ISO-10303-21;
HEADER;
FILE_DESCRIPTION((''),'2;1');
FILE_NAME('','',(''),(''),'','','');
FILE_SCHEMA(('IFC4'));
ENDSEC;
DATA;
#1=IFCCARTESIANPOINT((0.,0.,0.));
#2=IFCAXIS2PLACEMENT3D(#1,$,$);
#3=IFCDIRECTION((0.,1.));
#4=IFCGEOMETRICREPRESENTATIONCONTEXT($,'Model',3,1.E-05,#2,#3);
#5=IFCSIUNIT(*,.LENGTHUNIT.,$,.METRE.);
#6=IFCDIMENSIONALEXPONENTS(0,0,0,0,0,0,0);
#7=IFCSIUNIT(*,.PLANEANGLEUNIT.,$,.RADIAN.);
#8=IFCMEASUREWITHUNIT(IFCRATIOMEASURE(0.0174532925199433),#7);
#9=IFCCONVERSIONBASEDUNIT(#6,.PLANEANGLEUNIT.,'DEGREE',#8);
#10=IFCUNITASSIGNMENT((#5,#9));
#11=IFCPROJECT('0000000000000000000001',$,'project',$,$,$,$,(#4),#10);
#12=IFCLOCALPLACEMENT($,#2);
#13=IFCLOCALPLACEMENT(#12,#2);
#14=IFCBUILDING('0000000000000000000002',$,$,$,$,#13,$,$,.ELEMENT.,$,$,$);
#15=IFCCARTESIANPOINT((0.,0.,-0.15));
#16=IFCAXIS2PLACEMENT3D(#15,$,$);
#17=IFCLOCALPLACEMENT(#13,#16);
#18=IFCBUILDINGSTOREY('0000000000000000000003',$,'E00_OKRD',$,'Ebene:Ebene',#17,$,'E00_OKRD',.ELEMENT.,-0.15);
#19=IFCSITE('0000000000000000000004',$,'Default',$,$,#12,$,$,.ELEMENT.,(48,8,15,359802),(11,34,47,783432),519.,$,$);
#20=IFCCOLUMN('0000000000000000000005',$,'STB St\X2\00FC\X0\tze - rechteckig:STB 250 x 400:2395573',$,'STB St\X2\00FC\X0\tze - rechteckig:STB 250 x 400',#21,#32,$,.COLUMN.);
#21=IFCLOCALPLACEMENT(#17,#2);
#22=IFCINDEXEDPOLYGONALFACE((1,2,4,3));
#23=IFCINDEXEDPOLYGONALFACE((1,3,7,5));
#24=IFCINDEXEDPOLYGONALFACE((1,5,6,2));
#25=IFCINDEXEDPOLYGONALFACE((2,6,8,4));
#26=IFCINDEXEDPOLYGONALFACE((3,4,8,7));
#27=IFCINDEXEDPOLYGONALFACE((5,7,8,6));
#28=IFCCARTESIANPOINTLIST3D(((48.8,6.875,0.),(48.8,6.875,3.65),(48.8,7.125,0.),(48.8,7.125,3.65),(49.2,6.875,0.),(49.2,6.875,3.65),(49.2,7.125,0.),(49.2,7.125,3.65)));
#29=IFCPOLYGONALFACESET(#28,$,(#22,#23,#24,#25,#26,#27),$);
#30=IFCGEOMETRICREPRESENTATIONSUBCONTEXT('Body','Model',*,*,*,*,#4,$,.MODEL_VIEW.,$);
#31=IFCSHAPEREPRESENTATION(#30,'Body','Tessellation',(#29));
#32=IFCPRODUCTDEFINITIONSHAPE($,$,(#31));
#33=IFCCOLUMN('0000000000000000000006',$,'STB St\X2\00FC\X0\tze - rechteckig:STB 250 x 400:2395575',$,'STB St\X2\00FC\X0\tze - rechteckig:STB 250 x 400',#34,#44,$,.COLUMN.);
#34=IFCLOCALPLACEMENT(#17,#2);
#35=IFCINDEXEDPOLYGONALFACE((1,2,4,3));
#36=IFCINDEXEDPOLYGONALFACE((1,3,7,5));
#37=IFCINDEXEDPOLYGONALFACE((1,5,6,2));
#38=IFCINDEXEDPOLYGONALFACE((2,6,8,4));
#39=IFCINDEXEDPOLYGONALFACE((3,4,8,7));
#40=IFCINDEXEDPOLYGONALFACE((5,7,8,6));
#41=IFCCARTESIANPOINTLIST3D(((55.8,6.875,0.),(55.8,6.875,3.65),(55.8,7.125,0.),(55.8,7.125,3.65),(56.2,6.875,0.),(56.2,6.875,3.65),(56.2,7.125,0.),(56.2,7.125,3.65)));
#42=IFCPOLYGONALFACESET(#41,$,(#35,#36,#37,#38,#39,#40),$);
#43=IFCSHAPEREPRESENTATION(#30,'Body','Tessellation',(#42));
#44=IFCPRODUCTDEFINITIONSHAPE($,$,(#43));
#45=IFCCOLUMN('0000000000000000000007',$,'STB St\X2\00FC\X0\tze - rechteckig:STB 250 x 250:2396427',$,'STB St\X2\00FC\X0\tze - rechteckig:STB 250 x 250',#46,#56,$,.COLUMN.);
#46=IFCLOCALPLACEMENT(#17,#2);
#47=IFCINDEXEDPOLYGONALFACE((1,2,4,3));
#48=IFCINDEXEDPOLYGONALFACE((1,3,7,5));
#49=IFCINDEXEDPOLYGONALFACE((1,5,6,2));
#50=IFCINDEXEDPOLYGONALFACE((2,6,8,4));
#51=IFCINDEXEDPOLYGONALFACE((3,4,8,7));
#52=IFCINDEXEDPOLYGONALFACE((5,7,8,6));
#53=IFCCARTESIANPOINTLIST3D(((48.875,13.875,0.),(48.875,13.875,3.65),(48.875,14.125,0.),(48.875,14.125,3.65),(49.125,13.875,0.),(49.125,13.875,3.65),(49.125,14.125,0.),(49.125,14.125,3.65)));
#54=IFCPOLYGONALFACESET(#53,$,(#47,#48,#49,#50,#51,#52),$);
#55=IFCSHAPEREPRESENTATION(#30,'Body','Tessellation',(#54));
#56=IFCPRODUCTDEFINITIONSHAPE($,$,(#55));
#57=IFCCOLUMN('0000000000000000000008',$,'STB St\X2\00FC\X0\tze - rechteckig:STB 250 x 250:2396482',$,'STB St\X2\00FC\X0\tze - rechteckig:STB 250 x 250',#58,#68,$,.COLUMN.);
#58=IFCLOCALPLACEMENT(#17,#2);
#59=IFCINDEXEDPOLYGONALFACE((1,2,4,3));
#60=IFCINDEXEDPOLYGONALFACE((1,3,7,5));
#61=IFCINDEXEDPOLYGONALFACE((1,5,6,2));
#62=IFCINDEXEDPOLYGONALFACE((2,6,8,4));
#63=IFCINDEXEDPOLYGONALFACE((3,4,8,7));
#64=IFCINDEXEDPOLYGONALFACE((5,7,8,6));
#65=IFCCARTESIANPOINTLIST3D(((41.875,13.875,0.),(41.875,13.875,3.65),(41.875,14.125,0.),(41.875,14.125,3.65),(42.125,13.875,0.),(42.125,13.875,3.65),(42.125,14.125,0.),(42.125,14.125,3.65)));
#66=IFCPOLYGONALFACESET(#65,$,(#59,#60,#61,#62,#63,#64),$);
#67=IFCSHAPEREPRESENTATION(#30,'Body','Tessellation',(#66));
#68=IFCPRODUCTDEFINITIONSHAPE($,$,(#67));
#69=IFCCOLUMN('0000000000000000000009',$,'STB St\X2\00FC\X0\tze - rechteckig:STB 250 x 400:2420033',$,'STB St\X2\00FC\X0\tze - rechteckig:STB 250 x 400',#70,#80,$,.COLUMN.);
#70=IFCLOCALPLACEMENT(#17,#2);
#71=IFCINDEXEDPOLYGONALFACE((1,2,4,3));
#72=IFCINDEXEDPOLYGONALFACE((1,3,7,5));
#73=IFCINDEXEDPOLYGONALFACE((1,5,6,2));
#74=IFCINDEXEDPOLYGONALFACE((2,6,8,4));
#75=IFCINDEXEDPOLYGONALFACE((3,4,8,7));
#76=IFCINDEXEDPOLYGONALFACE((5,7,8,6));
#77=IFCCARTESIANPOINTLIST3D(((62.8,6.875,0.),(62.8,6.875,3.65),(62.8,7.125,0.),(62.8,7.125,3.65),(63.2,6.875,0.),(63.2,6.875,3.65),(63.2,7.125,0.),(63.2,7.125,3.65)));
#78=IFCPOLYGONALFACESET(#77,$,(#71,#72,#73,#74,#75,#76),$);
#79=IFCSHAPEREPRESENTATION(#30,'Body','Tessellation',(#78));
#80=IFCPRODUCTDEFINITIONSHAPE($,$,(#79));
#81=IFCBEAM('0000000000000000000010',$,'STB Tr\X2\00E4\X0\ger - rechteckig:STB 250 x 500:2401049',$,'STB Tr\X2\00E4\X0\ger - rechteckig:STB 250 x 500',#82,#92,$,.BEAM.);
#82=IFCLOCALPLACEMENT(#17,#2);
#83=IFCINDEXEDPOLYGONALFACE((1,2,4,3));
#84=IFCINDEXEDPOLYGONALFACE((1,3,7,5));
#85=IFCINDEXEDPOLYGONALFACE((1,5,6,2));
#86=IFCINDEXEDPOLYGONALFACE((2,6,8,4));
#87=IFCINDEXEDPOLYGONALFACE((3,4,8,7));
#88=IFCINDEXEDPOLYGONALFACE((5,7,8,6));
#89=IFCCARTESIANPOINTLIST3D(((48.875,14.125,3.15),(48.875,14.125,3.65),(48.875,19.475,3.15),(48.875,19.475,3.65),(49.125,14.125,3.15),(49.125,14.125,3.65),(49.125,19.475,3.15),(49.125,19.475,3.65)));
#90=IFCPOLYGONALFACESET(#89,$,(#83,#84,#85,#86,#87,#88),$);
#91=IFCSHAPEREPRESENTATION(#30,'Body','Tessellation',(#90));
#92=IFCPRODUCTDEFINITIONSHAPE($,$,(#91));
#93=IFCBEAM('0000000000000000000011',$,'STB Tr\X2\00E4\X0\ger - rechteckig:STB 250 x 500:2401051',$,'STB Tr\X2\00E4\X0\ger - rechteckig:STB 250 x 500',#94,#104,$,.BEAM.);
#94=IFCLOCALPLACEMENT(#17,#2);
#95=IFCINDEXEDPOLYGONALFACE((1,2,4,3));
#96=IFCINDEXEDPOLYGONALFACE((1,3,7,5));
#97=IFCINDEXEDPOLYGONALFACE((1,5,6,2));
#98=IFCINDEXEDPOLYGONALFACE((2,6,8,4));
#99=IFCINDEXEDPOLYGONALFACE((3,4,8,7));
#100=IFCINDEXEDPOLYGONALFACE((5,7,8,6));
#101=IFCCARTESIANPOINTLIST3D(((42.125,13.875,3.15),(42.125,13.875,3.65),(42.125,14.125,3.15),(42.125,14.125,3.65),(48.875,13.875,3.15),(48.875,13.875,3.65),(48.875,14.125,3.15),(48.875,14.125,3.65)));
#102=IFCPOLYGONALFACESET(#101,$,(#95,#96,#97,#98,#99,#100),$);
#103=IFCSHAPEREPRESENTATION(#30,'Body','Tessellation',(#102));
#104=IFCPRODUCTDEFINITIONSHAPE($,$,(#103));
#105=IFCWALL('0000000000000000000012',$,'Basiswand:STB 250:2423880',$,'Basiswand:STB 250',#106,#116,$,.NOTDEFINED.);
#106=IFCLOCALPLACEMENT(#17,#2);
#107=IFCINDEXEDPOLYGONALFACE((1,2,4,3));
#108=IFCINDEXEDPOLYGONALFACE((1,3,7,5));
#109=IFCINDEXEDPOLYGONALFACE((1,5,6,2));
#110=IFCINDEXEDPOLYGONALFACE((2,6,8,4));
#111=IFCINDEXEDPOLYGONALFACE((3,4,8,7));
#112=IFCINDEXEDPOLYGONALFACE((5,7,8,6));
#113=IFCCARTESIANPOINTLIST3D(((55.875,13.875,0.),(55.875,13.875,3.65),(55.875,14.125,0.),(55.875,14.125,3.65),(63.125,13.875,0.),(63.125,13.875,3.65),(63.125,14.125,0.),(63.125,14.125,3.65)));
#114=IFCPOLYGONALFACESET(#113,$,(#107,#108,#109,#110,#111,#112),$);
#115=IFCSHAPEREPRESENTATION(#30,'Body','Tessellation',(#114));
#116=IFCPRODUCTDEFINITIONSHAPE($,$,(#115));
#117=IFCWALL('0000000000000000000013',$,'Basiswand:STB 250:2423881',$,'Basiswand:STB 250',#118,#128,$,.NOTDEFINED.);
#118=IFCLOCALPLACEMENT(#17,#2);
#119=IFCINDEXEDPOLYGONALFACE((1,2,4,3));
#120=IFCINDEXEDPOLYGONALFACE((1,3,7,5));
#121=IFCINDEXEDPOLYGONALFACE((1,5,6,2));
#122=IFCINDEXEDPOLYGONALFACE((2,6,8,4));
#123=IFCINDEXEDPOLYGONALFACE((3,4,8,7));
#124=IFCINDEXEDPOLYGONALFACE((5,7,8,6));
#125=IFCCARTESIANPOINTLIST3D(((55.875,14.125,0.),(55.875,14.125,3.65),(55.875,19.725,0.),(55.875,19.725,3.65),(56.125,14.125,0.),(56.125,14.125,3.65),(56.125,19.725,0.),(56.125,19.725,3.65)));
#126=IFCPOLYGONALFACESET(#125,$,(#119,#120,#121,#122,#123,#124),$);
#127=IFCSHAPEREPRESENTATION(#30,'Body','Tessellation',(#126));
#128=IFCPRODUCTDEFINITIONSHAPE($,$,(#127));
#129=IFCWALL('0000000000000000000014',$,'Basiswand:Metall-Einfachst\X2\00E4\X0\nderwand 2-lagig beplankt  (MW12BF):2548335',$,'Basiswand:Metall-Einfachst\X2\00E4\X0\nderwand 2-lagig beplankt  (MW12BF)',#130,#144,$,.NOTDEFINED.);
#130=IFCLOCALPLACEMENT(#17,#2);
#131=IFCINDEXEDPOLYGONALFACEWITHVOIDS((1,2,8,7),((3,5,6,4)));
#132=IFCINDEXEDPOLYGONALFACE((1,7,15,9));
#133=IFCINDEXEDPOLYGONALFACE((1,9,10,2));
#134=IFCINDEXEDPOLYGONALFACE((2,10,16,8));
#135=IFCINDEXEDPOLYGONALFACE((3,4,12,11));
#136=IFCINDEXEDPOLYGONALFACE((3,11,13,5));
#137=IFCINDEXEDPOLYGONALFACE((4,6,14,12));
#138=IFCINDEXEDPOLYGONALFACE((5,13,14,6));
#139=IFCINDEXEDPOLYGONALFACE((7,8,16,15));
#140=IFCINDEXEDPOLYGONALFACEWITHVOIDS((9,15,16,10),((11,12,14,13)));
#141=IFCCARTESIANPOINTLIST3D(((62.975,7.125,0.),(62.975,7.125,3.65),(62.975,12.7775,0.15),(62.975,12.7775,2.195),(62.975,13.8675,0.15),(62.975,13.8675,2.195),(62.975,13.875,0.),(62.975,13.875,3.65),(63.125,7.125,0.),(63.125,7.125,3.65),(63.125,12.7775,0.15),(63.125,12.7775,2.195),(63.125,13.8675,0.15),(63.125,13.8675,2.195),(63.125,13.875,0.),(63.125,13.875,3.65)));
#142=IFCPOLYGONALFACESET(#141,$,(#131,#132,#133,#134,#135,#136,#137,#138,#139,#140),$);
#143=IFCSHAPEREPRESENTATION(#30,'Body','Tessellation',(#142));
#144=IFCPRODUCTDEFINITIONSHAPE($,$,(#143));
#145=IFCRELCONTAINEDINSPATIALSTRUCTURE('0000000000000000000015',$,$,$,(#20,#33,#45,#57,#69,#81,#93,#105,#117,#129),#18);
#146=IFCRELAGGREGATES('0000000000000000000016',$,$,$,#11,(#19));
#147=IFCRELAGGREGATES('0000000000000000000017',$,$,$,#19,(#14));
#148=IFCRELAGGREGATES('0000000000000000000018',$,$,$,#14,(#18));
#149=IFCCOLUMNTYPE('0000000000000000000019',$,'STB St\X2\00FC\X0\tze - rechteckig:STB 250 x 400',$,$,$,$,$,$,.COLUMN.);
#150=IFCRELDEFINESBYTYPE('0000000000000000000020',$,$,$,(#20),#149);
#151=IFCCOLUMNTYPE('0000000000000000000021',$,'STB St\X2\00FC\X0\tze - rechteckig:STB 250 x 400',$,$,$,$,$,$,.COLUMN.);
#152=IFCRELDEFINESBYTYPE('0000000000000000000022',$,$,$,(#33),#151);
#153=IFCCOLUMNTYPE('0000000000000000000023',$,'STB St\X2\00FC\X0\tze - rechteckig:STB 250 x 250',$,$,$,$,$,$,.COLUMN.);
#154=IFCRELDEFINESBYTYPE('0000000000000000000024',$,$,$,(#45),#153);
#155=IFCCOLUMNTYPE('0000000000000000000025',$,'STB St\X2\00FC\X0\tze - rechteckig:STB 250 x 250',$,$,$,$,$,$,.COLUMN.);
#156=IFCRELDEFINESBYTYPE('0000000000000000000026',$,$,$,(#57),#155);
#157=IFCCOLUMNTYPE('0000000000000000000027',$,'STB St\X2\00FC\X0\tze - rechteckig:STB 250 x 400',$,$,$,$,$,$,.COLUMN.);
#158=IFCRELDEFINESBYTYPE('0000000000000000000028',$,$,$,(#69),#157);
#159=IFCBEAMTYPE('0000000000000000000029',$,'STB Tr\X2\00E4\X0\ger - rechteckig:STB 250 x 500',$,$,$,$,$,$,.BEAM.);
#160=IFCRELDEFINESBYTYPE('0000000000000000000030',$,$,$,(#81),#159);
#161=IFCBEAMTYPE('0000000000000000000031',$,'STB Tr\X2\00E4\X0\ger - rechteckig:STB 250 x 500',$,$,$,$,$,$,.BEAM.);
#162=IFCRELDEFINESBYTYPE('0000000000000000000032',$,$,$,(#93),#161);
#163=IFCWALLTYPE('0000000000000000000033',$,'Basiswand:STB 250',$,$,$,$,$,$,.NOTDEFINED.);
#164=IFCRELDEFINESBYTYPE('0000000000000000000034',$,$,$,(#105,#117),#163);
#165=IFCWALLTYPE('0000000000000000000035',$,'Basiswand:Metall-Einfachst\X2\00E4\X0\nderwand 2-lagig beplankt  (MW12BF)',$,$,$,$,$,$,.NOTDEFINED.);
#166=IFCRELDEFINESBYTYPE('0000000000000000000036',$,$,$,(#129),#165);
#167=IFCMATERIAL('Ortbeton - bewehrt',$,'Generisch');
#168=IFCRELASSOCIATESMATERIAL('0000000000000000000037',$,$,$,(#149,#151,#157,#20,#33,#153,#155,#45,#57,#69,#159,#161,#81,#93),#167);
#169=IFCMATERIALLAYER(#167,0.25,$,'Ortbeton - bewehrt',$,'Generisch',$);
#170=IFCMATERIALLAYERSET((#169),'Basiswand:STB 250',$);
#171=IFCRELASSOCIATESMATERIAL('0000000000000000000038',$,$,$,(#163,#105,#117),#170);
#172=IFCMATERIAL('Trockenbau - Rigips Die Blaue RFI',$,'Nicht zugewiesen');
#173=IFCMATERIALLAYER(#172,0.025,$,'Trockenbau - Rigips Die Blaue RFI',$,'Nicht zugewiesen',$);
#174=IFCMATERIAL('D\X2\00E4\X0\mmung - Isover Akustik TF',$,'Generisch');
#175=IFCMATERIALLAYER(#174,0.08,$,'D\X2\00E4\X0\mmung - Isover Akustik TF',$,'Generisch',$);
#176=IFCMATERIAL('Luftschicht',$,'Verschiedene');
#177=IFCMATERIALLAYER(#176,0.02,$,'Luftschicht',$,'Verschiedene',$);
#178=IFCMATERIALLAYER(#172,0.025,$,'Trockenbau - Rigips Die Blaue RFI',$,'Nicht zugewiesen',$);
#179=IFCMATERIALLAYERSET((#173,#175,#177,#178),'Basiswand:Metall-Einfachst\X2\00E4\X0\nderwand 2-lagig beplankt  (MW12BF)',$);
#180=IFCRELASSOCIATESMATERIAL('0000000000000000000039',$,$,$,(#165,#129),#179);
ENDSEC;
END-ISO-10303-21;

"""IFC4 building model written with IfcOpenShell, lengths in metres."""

from ifc_helpers import new_model, entity, si_unit, converted_unit, direction, frame, frame_2d, origin, origin_2d_with_axis, place, context, subcontext, project, spatial, rectangle, extrude, source, transform, mapped, material, layer, layer_set, layer_usage, material_profile, profile_set, profile_usage, type_object, type_shapes, element, save


model = new_model("IFC4")

# Units and contexts
model_context = context("Model", 3, precision=1e-05, world=origin(), true_north=direction((0.0, 1.0)))
body_context = subcontext(model_context, "Body", "Model", "MODEL_VIEW")
ifc_project = project(units=[si_unit("LENGTHUNIT", "METRE"), converted_unit("PLANEANGLEUNIT", "DEGREE", entity("IfcRatioMeasure", 0.0174532925199433), si_unit("PLANEANGLEUNIT", "RADIAN"), dimensions=[0, 0, 0, 0, 0, 0, 0])], contexts=[model_context])

# Site, building, storey
site_placement = place(None, frame((0.0, 0.0, 0.0)))
site = spatial("IfcSite", under=ifc_project, at=site_placement, Name="Default", CompositionType="ELEMENT", RefLatitude=(48, 8, 15, 359802), RefLongitude=(11, 34, 47, 783432), RefElevation=519.0)
building_placement = place(site_placement, origin())
building = spatial("IfcBuilding", under=site, at=building_placement, CompositionType="ELEMENT")
storey_placement = place(building_placement, frame((0.0, 0.0, -0.15)))
storey = spatial("IfcBuildingStorey", under=building, at=storey_placement, Name="E00_OKRD", ObjectType="Ebene:Ebene", LongName="E00_OKRD", CompositionType="ELEMENT", Elevation=-0.15)

# Columns
ifc_material_1 = material(Name="Ortbeton - bewehrt", Category="Generisch")
ifc_material_profile_1 = material_profile(ifc_material_1, rectangle(XDim=0.4, YDim=0.25, at=frame_2d((0.0, 0.0), x_axis=(1.0, 0.0))), Name="STB 250 x 400")
ifc_profile_set_1 = profile_set([ifc_material_profile_1], Name="STB 250 x 400")
ifc_profile_usage_1 = profile_usage(ifc_profile_set_1)
column_type_1 = type_object("IfcColumnType", Name="STB Stütze - rechteckig:STB 250 x 400", PredefinedType="COLUMN", material=ifc_profile_set_1)
shared_shape_1 = source(origin(), body_context, "Body", "SweptSolid", [
    extrude(rectangle(XDim=0.4, YDim=0.25, at=frame_2d((0.0, 0.0), x_axis=(1.0, 0.0))), frame((0.2, 0.125, 0.0), z_axis=(0.0, 0.0, 1.0), x_axis=(-1.0, 0.0, 0.0)), (0.0, 0.0, 1.0), 3.65),
])
type_shapes(column_type_1, [shared_shape_1])
column_1_placement = place(storey_placement, frame((48.8, 6.875, 0.0)))
element("IfcColumn", 1, at=column_1_placement, inside=storey, type_object=column_type_1, material=ifc_profile_usage_1, Name="STB Stütze - rechteckig:STB 250 x 400:2395573", ObjectType="STB Stütze - rechteckig:STB 250 x 400", PredefinedType="COLUMN", context=body_context, shape_type="MappedRepresentation", body=[
    mapped(shared_shape_1, transform((0.0, 0.0, 0.0), scale=1.0)),
])
ifc_profile_usage_2 = profile_usage(ifc_profile_set_1)
column_type_2 = type_object("IfcColumnType", Name="STB Stütze - rechteckig:STB 250 x 400", PredefinedType="COLUMN", material=ifc_profile_set_1)
shared_shape_2 = source(origin(), body_context, "Body", "SweptSolid", [
    extrude(rectangle(XDim=0.4, YDim=0.25, at=frame_2d((0.0, 0.0), x_axis=(1.0, 0.0))), frame((0.2, 0.125, 0.0), z_axis=(0.0, 0.0, 1.0), x_axis=(-1.0, 0.0, 0.0)), (0.0, 0.0, 1.0), 3.65),
])
type_shapes(column_type_2, [shared_shape_2])
column_2_placement = place(storey_placement, frame((55.8, 6.875, 0.0)))
element("IfcColumn", 2, at=column_2_placement, inside=storey, type_object=column_type_2, material=ifc_profile_usage_2, Name="STB Stütze - rechteckig:STB 250 x 400:2395575", ObjectType="STB Stütze - rechteckig:STB 250 x 400", PredefinedType="COLUMN", context=body_context, shape_type="MappedRepresentation", body=[
    mapped(shared_shape_2, transform((0.0, 0.0, 0.0), scale=1.0)),
])
ifc_material_profile_2 = material_profile(ifc_material_1, rectangle(XDim=0.25, YDim=0.25, at=origin_2d_with_axis()), Name="STB 250 x 250")
ifc_profile_set_2 = profile_set([ifc_material_profile_2], Name="STB 250 x 250")
ifc_profile_usage_3 = profile_usage(ifc_profile_set_2)
column_type_3 = type_object("IfcColumnType", Name="STB Stütze - rechteckig:STB 250 x 250", PredefinedType="COLUMN", material=ifc_profile_set_2)
shared_shape_3 = source(origin(), body_context, "Body", "SweptSolid", [
    extrude(rectangle(XDim=0.25, YDim=0.25, at=frame_2d((0.0, 0.0), x_axis=(1.0, 0.0))), frame((0.125, 0.125, 0.0), z_axis=(0.0, 0.0, 1.0), x_axis=(-1.0, 0.0, 0.0)), (0.0, 0.0, 1.0), 3.65),
])
type_shapes(column_type_3, [shared_shape_3])
column_3_placement = place(storey_placement, frame((48.875, 13.875, 0.0)))
element("IfcColumn", 3, at=column_3_placement, inside=storey, type_object=column_type_3, material=ifc_profile_usage_3, Name="STB Stütze - rechteckig:STB 250 x 250:2396427", ObjectType="STB Stütze - rechteckig:STB 250 x 250", PredefinedType="COLUMN", context=body_context, shape_type="MappedRepresentation", body=[
    mapped(shared_shape_3, transform((0.0, 0.0, 0.0), scale=1.0)),
])
ifc_profile_usage_4 = profile_usage(ifc_profile_set_2)
column_type_4 = type_object("IfcColumnType", Name="STB Stütze - rechteckig:STB 250 x 250", PredefinedType="COLUMN", material=ifc_profile_set_2)
shared_shape_4 = source(origin(), body_context, "Body", "SweptSolid", [
    extrude(rectangle(XDim=0.25, YDim=0.25, at=frame_2d((0.0, 0.0), x_axis=(1.0, 0.0))), frame((0.125, 0.125, 0.0), z_axis=(0.0, 0.0, 1.0), x_axis=(-1.0, 0.0, 0.0)), (0.0, 0.0, 1.0), 3.65),
])
type_shapes(column_type_4, [shared_shape_4])
column_4_placement = place(storey_placement, frame((41.875, 13.875, 0.0)))
element("IfcColumn", 4, at=column_4_placement, inside=storey, type_object=column_type_4, material=ifc_profile_usage_4, Name="STB Stütze - rechteckig:STB 250 x 250:2396482", ObjectType="STB Stütze - rechteckig:STB 250 x 250", PredefinedType="COLUMN", context=body_context, shape_type="MappedRepresentation", body=[
    mapped(shared_shape_4, transform((0.0, 0.0, 0.0), scale=1.0)),
])
ifc_profile_usage_5 = profile_usage(ifc_profile_set_1)
column_type_5 = type_object("IfcColumnType", Name="STB Stütze - rechteckig:STB 250 x 400", PredefinedType="COLUMN", material=ifc_profile_set_1)
shared_shape_5 = source(origin(), body_context, "Body", "SweptSolid", [
    extrude(rectangle(XDim=0.4, YDim=0.25, at=frame_2d((0.0, 0.0), x_axis=(1.0, 0.0))), frame((0.2, 0.125, 0.0), z_axis=(0.0, 0.0, 1.0), x_axis=(-1.0, 0.0, 0.0)), (0.0, 0.0, 1.0), 3.65),
])
type_shapes(column_type_5, [shared_shape_5])
column_5_placement = place(storey_placement, frame((62.8, 6.875, 0.0)))
element("IfcColumn", 5, at=column_5_placement, inside=storey, type_object=column_type_5, material=ifc_profile_usage_5, Name="STB Stütze - rechteckig:STB 250 x 400:2420033", ObjectType="STB Stütze - rechteckig:STB 250 x 400", PredefinedType="COLUMN", context=body_context, shape_type="MappedRepresentation", body=[
    mapped(shared_shape_5, transform((0.0, 0.0, 0.0), scale=1.0)),
])

# Beams
ifc_material_profile_3 = material_profile(ifc_material_1, rectangle(XDim=0.5, YDim=0.25, at=frame_2d((0.0, 0.0), x_axis=(1.0, 0.0))), Name="STB 250 x 500")
ifc_profile_set_3 = profile_set([ifc_material_profile_3], Name="STB 250 x 500")
ifc_profile_usage_6 = profile_usage(ifc_profile_set_3, cardinal=8)
beam_type_1 = type_object("IfcBeamType", Name="STB Träger - rechteckig:STB 250 x 500", PredefinedType="BEAM", material=ifc_profile_set_3)
shared_shape_6 = source(origin(), body_context, "Body", "SweptSolid", [
    extrude(rectangle(XDim=0.5, YDim=5.35, at=frame_2d((0.0, 0.0), x_axis=(0.0, 1.0))), frame((0.0, 2.675, 0.25), z_axis=(1.0, 0.0, 0.0), x_axis=(0.0, -1.0, 0.0)), (0.0, 0.0, 1.0), 0.25),
])
type_shapes(beam_type_1, [shared_shape_6])
beam_1_placement = place(storey_placement, frame((48.875, 14.125, 3.15)))
element("IfcBeam", 6, at=beam_1_placement, inside=storey, type_object=beam_type_1, material=ifc_profile_usage_6, Name="STB Träger - rechteckig:STB 250 x 500:2401049", ObjectType="STB Träger - rechteckig:STB 250 x 500", PredefinedType="BEAM", context=body_context, shape_type="MappedRepresentation", body=[
    mapped(shared_shape_6, transform((0.0, 0.0, 0.0), scale=1.0)),
])
ifc_profile_usage_7 = profile_usage(ifc_profile_set_3, cardinal=8)
beam_type_2 = type_object("IfcBeamType", Name="STB Träger - rechteckig:STB 250 x 500", PredefinedType="BEAM", material=ifc_profile_set_3)
shared_shape_7 = source(origin(), body_context, "Body", "SweptSolid", [
    extrude(rectangle(XDim=0.5, YDim=0.25, at=origin_2d_with_axis()), frame((0.0, 0.125, 0.25), z_axis=(1.0, 0.0, 0.0), x_axis=(0.0, 0.0, -1.0)), (0.0, 0.0, 1.0), 6.75),
])
type_shapes(beam_type_2, [shared_shape_7])
beam_2_placement = place(storey_placement, frame((42.125, 13.875, 3.15)))
element("IfcBeam", 7, at=beam_2_placement, inside=storey, type_object=beam_type_2, material=ifc_profile_usage_7, Name="STB Träger - rechteckig:STB 250 x 500:2401051", ObjectType="STB Träger - rechteckig:STB 250 x 500", PredefinedType="BEAM", context=body_context, shape_type="MappedRepresentation", body=[
    mapped(shared_shape_7, transform((0.0, 0.0, 0.0), scale=1.0)),
])

# Walls
ifc_layer_1 = layer(ifc_material_1, 0.25, Name="Ortbeton - bewehrt", Category="Generisch")
ifc_layer_set_1 = layer_set([ifc_layer_1], Name="Basiswand:STB 250")
ifc_layer_usage_1 = layer_usage(ifc_layer_set_1, "AXIS2", "NEGATIVE", 0.125)
wall_type_1 = type_object("IfcWallType", Name="Basiswand:STB 250", PredefinedType="NOTDEFINED", material=ifc_layer_set_1)
wall_1_placement = place(storey_placement, frame((63.125, 14.0, 0.0), z_axis=(0.0, 0.0, 1.0), x_axis=(-1.0, 0.0, 0.0)))
element("IfcWall", 8, at=wall_1_placement, inside=storey, type_object=wall_type_1, material=ifc_layer_usage_1, Name="Basiswand:STB 250:2423880", ObjectType="Basiswand:STB 250", PredefinedType="NOTDEFINED", context=body_context, shape_type="SweptSolid", body=[
    extrude(rectangle(XDim=7.25, YDim=0.25, at=frame_2d((3.625, 0.0), x_axis=(-1.0, 0.0))), origin(), (0.0, 0.0, 1.0), 3.65),
])
ifc_layer_usage_2 = layer_usage(ifc_layer_set_1, "AXIS2", "NEGATIVE", 0.125)
wall_2_placement = place(storey_placement, frame((56.0, 14.125, 0.0), z_axis=(0.0, 0.0, 1.0), x_axis=(0.0, 1.0, 0.0)))
element("IfcWall", 9, at=wall_2_placement, inside=storey, type_object=wall_type_1, material=ifc_layer_usage_2, Name="Basiswand:STB 250:2423881", ObjectType="Basiswand:STB 250", PredefinedType="NOTDEFINED", context=body_context, shape_type="SweptSolid", body=[
    extrude(rectangle(XDim=5.6, YDim=0.25, at=frame_2d((2.8, 0.0), x_axis=(-1.0, 0.0))), origin(), (0.0, 0.0, 1.0), 3.65),
])

# Wall, opening
ifc_material_2 = material(Name="Trockenbau - Rigips Die Blaue RFI", Category="Nicht zugewiesen")
ifc_layer_2 = layer(ifc_material_2, 0.025, Name="Trockenbau - Rigips Die Blaue RFI", Category="Nicht zugewiesen")
ifc_material_3 = material(Name="Dämmung - Isover Akustik TF", Category="Generisch")
ifc_layer_3 = layer(ifc_material_3, 0.08, Name="Dämmung - Isover Akustik TF", Category="Generisch")
ifc_material_4 = material(Name="Luftschicht", Category="Verschiedene")
ifc_layer_4 = layer(ifc_material_4, 0.02, Name="Luftschicht", Category="Verschiedene")
ifc_layer_5 = layer(ifc_material_2, 0.025, Name="Trockenbau - Rigips Die Blaue RFI", Category="Nicht zugewiesen")
ifc_layer_set_2 = layer_set([ifc_layer_2, ifc_layer_3, ifc_layer_4, ifc_layer_5], Name="Basiswand:Metall-Einfachständerwand 2-lagig beplankt  (MW12BF)")
ifc_layer_usage_3 = layer_usage(ifc_layer_set_2, "AXIS2", "NEGATIVE", 0.075)
wall_type_2 = type_object("IfcWallType", Name="Basiswand:Metall-Einfachständerwand 2-lagig beplankt  (MW12BF)", PredefinedType="NOTDEFINED", material=ifc_layer_set_2)
wall_3_placement = place(storey_placement, frame((63.05, 13.875, 0.0), z_axis=(0.0, 0.0, 1.0), x_axis=(0.0, -1.0, 0.0)))
wall_3 = element("IfcWall", 10, at=wall_3_placement, inside=storey, type_object=wall_type_2, material=ifc_layer_usage_3, Name="Basiswand:Metall-Einfachständerwand 2-lagig beplankt  (MW12BF):2548335", ObjectType="Basiswand:Metall-Einfachständerwand 2-lagig beplankt  (MW12BF)", PredefinedType="NOTDEFINED", context=body_context, shape_type="SweptSolid", body=[
    extrude(rectangle(XDim=6.75, YDim=0.15, at=frame_2d((3.375, 0.0), x_axis=(-1.0, 0.0))), origin(), (0.0, 0.0, 1.0), 3.65),
])
opening_1_placement = place(wall_3_placement, frame((0.0075, -0.075, 0.15)))
element("IfcOpeningElement", 11, at=opening_1_placement, cuts=wall_3, ObjectType="Opening", PredefinedType="OPENING", context=body_context, shape_type="SweptSolid", body=[
    extrude(rectangle(XDim=2.045, YDim=1.09, at=frame_2d((1.0225, 0.545), x_axis=(-1.0, 0.0))), frame((0.0, 0.0, 0.0), z_axis=(0.0, 1.0, 0.0), x_axis=(0.0, 0.0, 1.0)), (0.0, 0.0, 1.0), 0.15),
])

save(model, "model.ifc")
